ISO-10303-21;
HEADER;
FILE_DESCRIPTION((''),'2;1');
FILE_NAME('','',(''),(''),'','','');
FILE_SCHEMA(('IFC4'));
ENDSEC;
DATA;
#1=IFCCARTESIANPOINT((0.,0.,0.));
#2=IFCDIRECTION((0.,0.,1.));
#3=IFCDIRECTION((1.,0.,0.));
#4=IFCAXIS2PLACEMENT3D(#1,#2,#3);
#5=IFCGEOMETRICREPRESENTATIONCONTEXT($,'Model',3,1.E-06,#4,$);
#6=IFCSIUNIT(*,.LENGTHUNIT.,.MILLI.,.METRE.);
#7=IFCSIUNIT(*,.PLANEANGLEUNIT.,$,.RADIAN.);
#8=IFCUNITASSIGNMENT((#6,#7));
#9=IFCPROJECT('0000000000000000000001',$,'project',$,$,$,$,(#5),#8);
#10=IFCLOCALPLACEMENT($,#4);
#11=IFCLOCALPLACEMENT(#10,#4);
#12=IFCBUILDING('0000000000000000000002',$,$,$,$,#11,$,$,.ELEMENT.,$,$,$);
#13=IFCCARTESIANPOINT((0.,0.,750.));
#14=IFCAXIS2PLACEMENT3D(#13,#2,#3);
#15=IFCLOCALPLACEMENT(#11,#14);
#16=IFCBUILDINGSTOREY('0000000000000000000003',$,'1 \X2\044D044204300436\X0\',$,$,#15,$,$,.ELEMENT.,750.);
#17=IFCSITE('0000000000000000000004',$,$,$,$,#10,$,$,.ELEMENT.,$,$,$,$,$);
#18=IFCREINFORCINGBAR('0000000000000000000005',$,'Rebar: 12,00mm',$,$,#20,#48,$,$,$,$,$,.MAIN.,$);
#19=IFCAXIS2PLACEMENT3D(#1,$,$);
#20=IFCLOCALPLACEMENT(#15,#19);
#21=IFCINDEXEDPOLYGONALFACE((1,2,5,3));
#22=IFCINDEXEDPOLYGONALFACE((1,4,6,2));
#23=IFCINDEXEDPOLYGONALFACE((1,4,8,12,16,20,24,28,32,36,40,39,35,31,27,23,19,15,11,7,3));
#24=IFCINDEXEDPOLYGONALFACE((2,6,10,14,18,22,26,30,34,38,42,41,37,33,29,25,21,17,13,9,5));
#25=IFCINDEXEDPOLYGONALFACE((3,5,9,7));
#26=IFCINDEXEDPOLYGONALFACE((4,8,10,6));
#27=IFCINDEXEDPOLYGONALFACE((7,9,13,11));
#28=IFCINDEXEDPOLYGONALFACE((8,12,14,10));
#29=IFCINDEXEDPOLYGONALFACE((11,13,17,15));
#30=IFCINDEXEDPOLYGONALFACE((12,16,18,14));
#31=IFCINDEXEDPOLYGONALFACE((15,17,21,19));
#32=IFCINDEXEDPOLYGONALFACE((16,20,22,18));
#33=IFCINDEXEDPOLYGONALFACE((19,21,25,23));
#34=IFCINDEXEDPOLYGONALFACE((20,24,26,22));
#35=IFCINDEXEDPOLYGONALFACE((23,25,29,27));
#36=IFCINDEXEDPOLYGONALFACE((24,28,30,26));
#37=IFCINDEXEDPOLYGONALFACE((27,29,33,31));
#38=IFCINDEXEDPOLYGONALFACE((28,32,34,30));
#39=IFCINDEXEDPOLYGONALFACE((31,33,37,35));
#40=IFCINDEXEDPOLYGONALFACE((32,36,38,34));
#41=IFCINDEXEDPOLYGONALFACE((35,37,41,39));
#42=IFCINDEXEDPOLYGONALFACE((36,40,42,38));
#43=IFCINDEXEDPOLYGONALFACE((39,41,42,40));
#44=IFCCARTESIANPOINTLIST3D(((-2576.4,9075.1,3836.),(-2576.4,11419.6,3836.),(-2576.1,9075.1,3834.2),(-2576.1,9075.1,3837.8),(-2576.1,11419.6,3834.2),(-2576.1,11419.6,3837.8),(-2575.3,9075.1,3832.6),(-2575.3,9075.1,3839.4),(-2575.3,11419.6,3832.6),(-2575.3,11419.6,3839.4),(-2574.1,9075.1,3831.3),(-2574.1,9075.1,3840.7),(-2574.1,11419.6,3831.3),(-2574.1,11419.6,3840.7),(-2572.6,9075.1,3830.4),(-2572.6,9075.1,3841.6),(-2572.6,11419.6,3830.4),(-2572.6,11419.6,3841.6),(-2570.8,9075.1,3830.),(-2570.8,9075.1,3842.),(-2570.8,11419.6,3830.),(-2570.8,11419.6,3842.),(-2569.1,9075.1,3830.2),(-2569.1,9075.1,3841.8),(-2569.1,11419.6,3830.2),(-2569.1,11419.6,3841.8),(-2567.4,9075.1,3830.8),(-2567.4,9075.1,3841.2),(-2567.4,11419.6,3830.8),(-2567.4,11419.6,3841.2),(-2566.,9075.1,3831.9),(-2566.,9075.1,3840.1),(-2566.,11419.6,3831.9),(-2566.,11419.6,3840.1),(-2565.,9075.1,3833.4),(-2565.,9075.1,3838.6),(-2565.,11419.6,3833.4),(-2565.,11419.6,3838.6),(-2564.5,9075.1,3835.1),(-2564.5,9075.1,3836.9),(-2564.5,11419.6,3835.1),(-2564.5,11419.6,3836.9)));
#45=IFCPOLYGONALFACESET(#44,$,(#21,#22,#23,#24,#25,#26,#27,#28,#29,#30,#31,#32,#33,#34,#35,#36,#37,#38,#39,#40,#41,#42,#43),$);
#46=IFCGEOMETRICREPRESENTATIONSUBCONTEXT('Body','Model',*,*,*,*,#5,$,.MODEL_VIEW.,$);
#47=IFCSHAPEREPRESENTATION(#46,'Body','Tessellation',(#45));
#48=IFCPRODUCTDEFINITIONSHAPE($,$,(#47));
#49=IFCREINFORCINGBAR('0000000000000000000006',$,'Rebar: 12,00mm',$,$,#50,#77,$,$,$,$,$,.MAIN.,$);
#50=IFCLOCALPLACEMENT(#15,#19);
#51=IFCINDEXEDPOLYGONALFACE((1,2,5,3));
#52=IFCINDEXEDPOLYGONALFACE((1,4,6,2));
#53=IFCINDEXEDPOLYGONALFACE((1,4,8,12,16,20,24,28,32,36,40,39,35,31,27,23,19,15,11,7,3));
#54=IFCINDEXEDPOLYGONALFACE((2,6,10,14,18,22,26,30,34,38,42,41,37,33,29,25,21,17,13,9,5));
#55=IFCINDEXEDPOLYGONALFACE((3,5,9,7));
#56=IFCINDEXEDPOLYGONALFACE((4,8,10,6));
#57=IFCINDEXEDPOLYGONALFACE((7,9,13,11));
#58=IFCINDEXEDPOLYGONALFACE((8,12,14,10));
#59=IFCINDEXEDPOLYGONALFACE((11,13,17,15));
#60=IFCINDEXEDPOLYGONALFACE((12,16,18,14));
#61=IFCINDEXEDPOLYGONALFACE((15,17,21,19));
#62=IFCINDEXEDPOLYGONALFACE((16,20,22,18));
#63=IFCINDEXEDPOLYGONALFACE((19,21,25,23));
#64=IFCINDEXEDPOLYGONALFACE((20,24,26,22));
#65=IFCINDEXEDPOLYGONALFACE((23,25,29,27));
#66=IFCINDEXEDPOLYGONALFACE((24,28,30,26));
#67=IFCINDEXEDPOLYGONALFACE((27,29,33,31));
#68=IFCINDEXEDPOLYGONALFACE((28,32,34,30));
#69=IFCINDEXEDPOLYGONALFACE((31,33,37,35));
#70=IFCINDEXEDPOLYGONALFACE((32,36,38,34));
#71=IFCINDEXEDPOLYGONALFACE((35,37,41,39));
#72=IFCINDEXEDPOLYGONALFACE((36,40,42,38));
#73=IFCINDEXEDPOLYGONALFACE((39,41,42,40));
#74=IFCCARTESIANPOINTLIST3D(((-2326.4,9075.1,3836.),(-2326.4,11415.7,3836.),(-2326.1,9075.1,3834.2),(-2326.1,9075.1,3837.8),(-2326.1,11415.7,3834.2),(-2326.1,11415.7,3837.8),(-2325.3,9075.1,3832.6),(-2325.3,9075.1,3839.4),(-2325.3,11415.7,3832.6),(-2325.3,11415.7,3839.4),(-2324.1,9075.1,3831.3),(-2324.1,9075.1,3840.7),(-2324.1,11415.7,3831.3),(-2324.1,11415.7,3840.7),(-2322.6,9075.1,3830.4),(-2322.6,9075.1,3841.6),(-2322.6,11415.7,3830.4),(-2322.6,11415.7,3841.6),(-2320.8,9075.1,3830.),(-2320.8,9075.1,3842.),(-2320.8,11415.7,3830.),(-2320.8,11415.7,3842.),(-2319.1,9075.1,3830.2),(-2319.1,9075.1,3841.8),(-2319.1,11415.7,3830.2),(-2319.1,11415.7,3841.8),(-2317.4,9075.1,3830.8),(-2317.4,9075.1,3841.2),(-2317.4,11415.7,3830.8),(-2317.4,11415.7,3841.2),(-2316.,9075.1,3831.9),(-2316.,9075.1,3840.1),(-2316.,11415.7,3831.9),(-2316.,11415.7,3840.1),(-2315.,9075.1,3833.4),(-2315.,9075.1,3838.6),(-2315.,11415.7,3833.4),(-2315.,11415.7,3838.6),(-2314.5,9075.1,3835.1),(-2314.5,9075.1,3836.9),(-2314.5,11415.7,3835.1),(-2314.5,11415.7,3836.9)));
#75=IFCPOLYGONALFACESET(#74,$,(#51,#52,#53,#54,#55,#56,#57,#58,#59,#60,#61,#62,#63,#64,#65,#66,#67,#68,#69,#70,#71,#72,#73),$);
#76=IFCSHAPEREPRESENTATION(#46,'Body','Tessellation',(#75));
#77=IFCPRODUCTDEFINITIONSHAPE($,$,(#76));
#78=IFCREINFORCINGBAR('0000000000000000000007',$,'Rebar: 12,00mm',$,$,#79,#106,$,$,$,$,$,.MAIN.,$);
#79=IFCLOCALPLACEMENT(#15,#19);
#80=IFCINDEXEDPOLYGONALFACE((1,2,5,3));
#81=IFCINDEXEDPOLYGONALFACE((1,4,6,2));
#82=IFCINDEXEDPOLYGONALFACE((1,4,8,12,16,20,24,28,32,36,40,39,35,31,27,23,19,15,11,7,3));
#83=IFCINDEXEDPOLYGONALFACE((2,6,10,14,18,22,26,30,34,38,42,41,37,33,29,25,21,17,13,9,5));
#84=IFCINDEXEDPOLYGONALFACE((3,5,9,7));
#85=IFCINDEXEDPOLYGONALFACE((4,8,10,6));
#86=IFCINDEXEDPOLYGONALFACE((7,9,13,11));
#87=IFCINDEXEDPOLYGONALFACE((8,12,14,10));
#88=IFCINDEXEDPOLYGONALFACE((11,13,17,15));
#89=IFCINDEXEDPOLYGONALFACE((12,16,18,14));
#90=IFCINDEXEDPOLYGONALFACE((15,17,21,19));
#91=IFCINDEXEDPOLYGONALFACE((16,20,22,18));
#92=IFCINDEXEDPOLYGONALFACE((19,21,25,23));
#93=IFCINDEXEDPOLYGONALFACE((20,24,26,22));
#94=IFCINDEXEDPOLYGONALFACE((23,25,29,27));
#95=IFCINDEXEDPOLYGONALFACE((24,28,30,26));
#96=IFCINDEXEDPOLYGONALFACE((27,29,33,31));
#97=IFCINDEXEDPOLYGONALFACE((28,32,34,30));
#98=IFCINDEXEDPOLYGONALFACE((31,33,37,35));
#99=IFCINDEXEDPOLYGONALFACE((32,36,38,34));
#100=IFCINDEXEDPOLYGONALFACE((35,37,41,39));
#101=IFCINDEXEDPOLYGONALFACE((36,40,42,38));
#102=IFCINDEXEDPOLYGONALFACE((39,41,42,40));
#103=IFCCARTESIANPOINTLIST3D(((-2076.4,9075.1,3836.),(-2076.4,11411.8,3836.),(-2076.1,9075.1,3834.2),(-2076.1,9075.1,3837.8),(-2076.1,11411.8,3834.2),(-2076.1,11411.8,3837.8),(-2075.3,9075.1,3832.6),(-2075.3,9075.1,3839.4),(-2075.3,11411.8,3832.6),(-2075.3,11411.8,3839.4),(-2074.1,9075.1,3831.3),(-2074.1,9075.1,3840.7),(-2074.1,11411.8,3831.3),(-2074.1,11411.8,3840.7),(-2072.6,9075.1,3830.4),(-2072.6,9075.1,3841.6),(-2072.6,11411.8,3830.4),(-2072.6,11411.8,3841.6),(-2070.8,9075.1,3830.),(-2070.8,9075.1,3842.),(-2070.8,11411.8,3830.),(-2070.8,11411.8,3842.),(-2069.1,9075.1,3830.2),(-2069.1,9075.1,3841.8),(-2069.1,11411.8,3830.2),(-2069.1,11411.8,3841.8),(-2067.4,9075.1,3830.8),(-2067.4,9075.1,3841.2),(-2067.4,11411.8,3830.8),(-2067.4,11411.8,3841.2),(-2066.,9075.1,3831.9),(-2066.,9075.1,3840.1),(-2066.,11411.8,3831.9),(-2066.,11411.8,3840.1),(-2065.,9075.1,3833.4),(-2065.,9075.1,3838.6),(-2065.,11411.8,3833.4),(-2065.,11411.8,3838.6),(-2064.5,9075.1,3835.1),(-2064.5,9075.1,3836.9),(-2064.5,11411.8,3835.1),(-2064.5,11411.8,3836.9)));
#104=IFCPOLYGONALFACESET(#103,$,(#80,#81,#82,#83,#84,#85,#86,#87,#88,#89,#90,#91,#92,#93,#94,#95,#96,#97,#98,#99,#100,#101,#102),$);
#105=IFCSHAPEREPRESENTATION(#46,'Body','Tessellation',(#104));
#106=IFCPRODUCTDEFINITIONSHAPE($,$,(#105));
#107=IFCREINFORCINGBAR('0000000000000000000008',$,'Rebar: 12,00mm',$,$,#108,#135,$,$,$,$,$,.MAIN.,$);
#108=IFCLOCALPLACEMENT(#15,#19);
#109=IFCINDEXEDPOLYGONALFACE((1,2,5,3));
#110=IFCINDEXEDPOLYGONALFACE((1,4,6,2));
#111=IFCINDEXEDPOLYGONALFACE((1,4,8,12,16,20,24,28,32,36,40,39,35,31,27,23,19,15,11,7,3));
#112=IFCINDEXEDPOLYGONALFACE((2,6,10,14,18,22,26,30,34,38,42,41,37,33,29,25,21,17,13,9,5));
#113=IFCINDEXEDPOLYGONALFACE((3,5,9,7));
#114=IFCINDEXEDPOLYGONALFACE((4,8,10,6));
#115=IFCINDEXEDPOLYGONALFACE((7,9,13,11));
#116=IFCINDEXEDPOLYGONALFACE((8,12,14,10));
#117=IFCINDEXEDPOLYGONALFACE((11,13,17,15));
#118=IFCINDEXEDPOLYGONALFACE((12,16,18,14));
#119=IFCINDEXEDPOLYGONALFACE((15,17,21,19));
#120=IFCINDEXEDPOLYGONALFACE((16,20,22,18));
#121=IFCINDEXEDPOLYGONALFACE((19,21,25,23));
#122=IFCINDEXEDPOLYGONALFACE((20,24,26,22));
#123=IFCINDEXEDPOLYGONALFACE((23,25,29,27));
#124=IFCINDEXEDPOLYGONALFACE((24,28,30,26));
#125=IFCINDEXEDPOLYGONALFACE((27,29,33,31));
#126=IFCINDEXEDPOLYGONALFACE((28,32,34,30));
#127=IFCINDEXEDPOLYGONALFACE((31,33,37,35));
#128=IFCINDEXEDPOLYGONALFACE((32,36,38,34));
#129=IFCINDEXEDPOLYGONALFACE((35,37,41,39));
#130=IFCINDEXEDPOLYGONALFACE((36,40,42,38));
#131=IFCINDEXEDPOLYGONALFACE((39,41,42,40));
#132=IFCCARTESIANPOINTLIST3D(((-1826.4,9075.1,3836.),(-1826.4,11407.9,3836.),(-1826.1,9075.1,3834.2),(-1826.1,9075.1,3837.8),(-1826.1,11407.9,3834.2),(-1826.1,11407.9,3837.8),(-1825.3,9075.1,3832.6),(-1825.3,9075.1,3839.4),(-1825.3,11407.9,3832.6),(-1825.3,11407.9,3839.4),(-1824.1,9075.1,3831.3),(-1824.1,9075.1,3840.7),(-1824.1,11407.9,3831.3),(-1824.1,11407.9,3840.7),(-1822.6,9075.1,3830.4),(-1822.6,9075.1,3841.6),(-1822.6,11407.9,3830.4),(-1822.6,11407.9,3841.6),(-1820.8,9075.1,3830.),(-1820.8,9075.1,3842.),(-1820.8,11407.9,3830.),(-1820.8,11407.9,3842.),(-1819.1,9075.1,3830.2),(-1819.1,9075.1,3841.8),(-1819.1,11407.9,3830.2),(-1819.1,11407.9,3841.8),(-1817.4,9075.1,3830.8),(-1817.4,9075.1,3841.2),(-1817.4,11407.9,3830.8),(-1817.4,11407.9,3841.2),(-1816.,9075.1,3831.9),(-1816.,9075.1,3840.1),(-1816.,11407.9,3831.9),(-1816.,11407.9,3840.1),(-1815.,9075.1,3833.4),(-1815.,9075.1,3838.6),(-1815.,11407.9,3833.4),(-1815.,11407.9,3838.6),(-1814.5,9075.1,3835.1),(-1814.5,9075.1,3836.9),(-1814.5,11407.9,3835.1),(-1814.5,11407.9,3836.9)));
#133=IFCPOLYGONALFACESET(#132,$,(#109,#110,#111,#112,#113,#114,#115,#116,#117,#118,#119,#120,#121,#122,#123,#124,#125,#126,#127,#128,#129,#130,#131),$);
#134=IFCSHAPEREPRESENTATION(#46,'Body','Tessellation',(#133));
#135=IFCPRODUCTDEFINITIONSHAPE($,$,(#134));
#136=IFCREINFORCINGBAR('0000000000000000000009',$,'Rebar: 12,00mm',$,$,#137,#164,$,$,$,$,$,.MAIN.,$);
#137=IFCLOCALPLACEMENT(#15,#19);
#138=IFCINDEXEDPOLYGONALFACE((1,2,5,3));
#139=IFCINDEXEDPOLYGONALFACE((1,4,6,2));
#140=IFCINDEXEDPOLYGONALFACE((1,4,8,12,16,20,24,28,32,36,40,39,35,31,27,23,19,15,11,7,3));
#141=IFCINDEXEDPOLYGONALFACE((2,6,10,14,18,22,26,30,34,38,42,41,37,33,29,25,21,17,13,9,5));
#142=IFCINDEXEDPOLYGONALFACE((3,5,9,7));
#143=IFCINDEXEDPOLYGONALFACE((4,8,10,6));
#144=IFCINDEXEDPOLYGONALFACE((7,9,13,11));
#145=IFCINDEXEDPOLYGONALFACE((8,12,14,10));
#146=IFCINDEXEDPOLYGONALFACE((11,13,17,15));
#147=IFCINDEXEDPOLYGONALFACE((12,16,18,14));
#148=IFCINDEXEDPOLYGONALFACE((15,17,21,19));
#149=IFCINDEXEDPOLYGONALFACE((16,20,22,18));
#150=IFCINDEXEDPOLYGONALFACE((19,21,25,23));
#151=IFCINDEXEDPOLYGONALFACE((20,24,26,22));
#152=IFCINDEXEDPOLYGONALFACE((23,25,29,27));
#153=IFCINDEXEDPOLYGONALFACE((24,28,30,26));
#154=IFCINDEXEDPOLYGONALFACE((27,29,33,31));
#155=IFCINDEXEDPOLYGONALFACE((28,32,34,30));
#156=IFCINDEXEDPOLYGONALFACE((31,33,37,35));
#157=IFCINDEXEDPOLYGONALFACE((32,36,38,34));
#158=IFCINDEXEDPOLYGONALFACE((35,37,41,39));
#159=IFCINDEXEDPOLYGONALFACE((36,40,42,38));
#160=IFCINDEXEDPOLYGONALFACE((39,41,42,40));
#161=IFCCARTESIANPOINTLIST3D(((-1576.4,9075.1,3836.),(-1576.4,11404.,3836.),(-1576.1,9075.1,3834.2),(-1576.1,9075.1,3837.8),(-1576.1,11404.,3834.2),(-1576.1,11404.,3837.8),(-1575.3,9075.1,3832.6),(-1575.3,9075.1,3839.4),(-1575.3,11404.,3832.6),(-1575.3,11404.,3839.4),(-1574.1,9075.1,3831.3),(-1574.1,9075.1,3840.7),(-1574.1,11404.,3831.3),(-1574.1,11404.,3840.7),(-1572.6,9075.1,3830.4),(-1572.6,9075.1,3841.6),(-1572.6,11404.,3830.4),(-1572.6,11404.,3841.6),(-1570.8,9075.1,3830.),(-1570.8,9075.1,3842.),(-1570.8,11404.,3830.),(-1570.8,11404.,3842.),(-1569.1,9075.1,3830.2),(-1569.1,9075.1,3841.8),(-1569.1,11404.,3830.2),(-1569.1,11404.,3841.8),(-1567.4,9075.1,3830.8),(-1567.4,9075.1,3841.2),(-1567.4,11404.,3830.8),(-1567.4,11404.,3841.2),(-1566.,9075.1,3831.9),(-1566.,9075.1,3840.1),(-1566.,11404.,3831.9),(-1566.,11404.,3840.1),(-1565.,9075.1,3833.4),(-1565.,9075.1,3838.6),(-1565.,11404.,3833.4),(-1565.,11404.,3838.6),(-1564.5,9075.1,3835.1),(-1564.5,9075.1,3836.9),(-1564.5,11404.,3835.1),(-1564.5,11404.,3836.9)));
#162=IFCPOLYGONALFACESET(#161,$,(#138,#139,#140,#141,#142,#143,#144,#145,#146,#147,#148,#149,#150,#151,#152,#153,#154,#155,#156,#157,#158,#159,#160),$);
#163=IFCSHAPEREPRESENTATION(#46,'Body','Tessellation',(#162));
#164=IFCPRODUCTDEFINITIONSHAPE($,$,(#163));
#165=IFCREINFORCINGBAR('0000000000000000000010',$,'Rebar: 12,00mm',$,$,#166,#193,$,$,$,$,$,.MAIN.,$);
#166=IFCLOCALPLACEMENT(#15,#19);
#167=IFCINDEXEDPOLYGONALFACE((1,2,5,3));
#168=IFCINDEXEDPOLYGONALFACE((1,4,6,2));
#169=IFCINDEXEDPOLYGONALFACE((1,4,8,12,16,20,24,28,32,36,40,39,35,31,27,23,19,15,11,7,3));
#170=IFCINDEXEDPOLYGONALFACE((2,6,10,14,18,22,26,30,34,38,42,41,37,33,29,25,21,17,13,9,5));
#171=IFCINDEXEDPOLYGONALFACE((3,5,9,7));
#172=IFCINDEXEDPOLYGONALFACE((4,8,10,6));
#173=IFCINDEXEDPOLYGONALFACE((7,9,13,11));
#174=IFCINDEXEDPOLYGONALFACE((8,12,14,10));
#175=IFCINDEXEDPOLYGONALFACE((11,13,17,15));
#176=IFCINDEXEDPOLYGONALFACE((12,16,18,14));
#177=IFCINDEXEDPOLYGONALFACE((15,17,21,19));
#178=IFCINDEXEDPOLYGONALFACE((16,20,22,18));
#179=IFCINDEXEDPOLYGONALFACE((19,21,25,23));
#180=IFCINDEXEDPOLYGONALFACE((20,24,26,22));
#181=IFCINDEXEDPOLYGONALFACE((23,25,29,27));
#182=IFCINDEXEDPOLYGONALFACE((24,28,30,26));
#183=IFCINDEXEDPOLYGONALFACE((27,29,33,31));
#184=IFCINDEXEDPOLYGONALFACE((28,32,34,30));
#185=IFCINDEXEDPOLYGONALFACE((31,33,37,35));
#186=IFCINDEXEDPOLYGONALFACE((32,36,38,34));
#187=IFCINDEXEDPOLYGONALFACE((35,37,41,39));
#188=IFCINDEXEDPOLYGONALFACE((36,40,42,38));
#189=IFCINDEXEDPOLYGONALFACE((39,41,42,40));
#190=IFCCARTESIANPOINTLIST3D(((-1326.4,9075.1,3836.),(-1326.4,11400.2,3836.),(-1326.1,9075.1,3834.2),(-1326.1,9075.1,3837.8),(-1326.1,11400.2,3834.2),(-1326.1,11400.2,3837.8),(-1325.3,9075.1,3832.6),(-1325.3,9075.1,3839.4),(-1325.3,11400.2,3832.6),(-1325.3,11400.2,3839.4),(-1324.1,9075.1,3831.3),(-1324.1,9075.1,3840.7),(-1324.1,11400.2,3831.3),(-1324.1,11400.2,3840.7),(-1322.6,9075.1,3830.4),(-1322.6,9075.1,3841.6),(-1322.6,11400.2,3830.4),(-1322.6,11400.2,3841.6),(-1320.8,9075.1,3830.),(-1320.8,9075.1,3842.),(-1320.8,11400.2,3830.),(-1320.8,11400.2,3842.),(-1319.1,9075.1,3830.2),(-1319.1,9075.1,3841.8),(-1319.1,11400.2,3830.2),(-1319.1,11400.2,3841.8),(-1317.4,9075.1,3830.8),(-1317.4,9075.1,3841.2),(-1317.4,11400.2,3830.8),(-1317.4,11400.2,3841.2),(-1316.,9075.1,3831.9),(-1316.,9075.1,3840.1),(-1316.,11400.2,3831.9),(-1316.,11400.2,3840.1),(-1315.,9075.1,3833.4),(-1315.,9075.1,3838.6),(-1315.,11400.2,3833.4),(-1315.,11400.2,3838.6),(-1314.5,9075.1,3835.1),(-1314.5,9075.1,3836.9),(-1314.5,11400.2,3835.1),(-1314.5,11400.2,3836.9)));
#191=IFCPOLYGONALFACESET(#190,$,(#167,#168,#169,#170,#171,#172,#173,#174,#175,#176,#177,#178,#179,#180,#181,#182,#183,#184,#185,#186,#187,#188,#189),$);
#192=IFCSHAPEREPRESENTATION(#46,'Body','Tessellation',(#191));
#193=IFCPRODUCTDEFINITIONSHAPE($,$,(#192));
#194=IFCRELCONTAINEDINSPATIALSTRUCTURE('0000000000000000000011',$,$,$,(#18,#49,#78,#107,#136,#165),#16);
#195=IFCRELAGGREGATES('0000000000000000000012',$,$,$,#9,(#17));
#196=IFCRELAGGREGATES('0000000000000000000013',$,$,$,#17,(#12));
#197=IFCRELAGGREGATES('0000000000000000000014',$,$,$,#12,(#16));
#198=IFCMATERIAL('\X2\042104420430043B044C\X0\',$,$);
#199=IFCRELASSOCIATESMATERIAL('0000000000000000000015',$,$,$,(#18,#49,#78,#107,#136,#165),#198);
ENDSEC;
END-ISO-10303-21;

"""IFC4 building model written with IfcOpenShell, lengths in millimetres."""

from ifc_helpers import new_model, entity, si_unit, frame, origin_with_axes, place, context, subcontext, project, spatial, source, transform, mapped, material, element, save


model = new_model("IFC4")

# Units and contexts
model_context = context("Model", 3, precision=1e-06, world=origin_with_axes())
body_context = subcontext(model_context, "Body", "Model", "MODEL_VIEW")
ifc_project = project(units=[si_unit("LENGTHUNIT", "METRE", prefix="MILLI"), si_unit("PLANEANGLEUNIT", "RADIAN")], contexts=[model_context])

# Site, building, storey
site_placement = place(None, origin_with_axes())
site = spatial("IfcSite", under=ifc_project, at=site_placement, CompositionType="ELEMENT")
building_placement = place(site_placement, origin_with_axes())
building = spatial("IfcBuilding", under=site, at=building_placement, CompositionType="ELEMENT")
storey_placement = place(building_placement, frame((0.0, 0.0, 750.0), z_axis=(0.0, 0.0, 1.0), x_axis=(1.0, 0.0, 0.0)))
storey = spatial("IfcBuildingStorey", under=building, at=storey_placement, Name="1 этаж", CompositionType="ELEMENT", Elevation=750.0)

# Reinforcing bars
ifc_material = material(Name="Сталь")
shared_shape_1 = source(origin_with_axes(), body_context, "Body", "AdvancedSweptSolid", [
    entity("IfcSweptDiskSolid", entity("IfcIndexedPolyCurve", entity("IfcCartesianPointList3D", [[0.0, 0.0, 0.0], [2344.4, 0.0, 0.0]]), [entity("IfcLineIndex", [1, 2])]), 6.0),
])
reinforcing_bar_1_placement = place(storey_placement, origin_with_axes())
element("IfcReinforcingBar", 1, at=reinforcing_bar_1_placement, inside=storey, material=ifc_material, Name="Rebar: 12,00mm", PredefinedType="MAIN", context=body_context, shape_type="MappedRepresentation", body=[
    mapped(shared_shape_1, transform((-2570.4, 9075.1, 3836.0), x_axis=(0.0, 1.0, 0.0), y_axis=(-1.0, 0.0, 0.0), z_axis=(0.0, 0.0, 1.0), scale=1.0)),
])
shared_shape_2 = source(origin_with_axes(), body_context, "Body", "AdvancedSweptSolid", [
    entity("IfcSweptDiskSolid", entity("IfcIndexedPolyCurve", entity("IfcCartesianPointList3D", [[0.0, 0.0, 0.0], [2340.5, 0.0, 0.0]]), [entity("IfcLineIndex", [1, 2])]), 6.0),
])
reinforcing_bar_2_placement = place(storey_placement, origin_with_axes())
element("IfcReinforcingBar", 2, at=reinforcing_bar_2_placement, inside=storey, material=ifc_material, Name="Rebar: 12,00mm", PredefinedType="MAIN", context=body_context, shape_type="MappedRepresentation", body=[
    mapped(shared_shape_2, transform((-2320.4, 9075.1, 3836.0), x_axis=(0.0, 1.0, 0.0), y_axis=(-1.0, 0.0, 0.0), z_axis=(0.0, 0.0, 1.0), scale=1.0)),
])
shared_shape_3 = source(origin_with_axes(), body_context, "Body", "AdvancedSweptSolid", [
    entity("IfcSweptDiskSolid", entity("IfcIndexedPolyCurve", entity("IfcCartesianPointList3D", [[0.0, 0.0, 0.0], [2336.7, 0.0, 0.0]]), [entity("IfcLineIndex", [1, 2])]), 6.0),
])
reinforcing_bar_3_placement = place(storey_placement, origin_with_axes())
element("IfcReinforcingBar", 3, at=reinforcing_bar_3_placement, inside=storey, material=ifc_material, Name="Rebar: 12,00mm", PredefinedType="MAIN", context=body_context, shape_type="MappedRepresentation", body=[
    mapped(shared_shape_3, transform((-2070.4, 9075.1, 3836.0), x_axis=(0.0, 1.0, 0.0), y_axis=(-1.0, 0.0, 0.0), z_axis=(0.0, 0.0, 1.0), scale=1.0)),
])
shared_shape_4 = source(origin_with_axes(), body_context, "Body", "AdvancedSweptSolid", [
    entity("IfcSweptDiskSolid", entity("IfcIndexedPolyCurve", entity("IfcCartesianPointList3D", [[0.0, 0.0, 0.0], [2332.8, 0.0, 0.0]]), [entity("IfcLineIndex", [1, 2])]), 6.0),
])
reinforcing_bar_4_placement = place(storey_placement, origin_with_axes())
element("IfcReinforcingBar", 4, at=reinforcing_bar_4_placement, inside=storey, material=ifc_material, Name="Rebar: 12,00mm", PredefinedType="MAIN", context=body_context, shape_type="MappedRepresentation", body=[
    mapped(shared_shape_4, transform((-1820.4, 9075.1, 3836.0), x_axis=(0.0, 1.0, 0.0), y_axis=(-1.0, 0.0, 0.0), z_axis=(0.0, 0.0, 1.0), scale=1.0)),
])
shared_shape_5 = source(origin_with_axes(), body_context, "Body", "AdvancedSweptSolid", [
    entity("IfcSweptDiskSolid", entity("IfcIndexedPolyCurve", entity("IfcCartesianPointList3D", [[0.0, 0.0, 0.0], [2328.9, 0.0, 0.0]]), [entity("IfcLineIndex", [1, 2])]), 6.0),
])
reinforcing_bar_5_placement = place(storey_placement, origin_with_axes())
element("IfcReinforcingBar", 5, at=reinforcing_bar_5_placement, inside=storey, material=ifc_material, Name="Rebar: 12,00mm", PredefinedType="MAIN", context=body_context, shape_type="MappedRepresentation", body=[
    mapped(shared_shape_5, transform((-1570.4, 9075.1, 3836.0), x_axis=(0.0, 1.0, 0.0), y_axis=(-1.0, 0.0, 0.0), z_axis=(0.0, 0.0, 1.0), scale=1.0)),
])
shared_shape_6 = source(origin_with_axes(), body_context, "Body", "AdvancedSweptSolid", [
    entity("IfcSweptDiskSolid", entity("IfcIndexedPolyCurve", entity("IfcCartesianPointList3D", [[0.0, 0.0, 0.0], [2325.0, 0.0, 0.0]]), [entity("IfcLineIndex", [1, 2])]), 6.0),
])
reinforcing_bar_6_placement = place(storey_placement, origin_with_axes())
element("IfcReinforcingBar", 6, at=reinforcing_bar_6_placement, inside=storey, material=ifc_material, Name="Rebar: 12,00mm", PredefinedType="MAIN", context=body_context, shape_type="MappedRepresentation", body=[
    mapped(shared_shape_6, transform((-1320.4, 9075.1, 3836.0), x_axis=(0.0, 1.0, 0.0), y_axis=(-1.0, 0.0, 0.0), z_axis=(0.0, 0.0, 1.0), scale=1.0)),
])

save(model, "model.ifc")
